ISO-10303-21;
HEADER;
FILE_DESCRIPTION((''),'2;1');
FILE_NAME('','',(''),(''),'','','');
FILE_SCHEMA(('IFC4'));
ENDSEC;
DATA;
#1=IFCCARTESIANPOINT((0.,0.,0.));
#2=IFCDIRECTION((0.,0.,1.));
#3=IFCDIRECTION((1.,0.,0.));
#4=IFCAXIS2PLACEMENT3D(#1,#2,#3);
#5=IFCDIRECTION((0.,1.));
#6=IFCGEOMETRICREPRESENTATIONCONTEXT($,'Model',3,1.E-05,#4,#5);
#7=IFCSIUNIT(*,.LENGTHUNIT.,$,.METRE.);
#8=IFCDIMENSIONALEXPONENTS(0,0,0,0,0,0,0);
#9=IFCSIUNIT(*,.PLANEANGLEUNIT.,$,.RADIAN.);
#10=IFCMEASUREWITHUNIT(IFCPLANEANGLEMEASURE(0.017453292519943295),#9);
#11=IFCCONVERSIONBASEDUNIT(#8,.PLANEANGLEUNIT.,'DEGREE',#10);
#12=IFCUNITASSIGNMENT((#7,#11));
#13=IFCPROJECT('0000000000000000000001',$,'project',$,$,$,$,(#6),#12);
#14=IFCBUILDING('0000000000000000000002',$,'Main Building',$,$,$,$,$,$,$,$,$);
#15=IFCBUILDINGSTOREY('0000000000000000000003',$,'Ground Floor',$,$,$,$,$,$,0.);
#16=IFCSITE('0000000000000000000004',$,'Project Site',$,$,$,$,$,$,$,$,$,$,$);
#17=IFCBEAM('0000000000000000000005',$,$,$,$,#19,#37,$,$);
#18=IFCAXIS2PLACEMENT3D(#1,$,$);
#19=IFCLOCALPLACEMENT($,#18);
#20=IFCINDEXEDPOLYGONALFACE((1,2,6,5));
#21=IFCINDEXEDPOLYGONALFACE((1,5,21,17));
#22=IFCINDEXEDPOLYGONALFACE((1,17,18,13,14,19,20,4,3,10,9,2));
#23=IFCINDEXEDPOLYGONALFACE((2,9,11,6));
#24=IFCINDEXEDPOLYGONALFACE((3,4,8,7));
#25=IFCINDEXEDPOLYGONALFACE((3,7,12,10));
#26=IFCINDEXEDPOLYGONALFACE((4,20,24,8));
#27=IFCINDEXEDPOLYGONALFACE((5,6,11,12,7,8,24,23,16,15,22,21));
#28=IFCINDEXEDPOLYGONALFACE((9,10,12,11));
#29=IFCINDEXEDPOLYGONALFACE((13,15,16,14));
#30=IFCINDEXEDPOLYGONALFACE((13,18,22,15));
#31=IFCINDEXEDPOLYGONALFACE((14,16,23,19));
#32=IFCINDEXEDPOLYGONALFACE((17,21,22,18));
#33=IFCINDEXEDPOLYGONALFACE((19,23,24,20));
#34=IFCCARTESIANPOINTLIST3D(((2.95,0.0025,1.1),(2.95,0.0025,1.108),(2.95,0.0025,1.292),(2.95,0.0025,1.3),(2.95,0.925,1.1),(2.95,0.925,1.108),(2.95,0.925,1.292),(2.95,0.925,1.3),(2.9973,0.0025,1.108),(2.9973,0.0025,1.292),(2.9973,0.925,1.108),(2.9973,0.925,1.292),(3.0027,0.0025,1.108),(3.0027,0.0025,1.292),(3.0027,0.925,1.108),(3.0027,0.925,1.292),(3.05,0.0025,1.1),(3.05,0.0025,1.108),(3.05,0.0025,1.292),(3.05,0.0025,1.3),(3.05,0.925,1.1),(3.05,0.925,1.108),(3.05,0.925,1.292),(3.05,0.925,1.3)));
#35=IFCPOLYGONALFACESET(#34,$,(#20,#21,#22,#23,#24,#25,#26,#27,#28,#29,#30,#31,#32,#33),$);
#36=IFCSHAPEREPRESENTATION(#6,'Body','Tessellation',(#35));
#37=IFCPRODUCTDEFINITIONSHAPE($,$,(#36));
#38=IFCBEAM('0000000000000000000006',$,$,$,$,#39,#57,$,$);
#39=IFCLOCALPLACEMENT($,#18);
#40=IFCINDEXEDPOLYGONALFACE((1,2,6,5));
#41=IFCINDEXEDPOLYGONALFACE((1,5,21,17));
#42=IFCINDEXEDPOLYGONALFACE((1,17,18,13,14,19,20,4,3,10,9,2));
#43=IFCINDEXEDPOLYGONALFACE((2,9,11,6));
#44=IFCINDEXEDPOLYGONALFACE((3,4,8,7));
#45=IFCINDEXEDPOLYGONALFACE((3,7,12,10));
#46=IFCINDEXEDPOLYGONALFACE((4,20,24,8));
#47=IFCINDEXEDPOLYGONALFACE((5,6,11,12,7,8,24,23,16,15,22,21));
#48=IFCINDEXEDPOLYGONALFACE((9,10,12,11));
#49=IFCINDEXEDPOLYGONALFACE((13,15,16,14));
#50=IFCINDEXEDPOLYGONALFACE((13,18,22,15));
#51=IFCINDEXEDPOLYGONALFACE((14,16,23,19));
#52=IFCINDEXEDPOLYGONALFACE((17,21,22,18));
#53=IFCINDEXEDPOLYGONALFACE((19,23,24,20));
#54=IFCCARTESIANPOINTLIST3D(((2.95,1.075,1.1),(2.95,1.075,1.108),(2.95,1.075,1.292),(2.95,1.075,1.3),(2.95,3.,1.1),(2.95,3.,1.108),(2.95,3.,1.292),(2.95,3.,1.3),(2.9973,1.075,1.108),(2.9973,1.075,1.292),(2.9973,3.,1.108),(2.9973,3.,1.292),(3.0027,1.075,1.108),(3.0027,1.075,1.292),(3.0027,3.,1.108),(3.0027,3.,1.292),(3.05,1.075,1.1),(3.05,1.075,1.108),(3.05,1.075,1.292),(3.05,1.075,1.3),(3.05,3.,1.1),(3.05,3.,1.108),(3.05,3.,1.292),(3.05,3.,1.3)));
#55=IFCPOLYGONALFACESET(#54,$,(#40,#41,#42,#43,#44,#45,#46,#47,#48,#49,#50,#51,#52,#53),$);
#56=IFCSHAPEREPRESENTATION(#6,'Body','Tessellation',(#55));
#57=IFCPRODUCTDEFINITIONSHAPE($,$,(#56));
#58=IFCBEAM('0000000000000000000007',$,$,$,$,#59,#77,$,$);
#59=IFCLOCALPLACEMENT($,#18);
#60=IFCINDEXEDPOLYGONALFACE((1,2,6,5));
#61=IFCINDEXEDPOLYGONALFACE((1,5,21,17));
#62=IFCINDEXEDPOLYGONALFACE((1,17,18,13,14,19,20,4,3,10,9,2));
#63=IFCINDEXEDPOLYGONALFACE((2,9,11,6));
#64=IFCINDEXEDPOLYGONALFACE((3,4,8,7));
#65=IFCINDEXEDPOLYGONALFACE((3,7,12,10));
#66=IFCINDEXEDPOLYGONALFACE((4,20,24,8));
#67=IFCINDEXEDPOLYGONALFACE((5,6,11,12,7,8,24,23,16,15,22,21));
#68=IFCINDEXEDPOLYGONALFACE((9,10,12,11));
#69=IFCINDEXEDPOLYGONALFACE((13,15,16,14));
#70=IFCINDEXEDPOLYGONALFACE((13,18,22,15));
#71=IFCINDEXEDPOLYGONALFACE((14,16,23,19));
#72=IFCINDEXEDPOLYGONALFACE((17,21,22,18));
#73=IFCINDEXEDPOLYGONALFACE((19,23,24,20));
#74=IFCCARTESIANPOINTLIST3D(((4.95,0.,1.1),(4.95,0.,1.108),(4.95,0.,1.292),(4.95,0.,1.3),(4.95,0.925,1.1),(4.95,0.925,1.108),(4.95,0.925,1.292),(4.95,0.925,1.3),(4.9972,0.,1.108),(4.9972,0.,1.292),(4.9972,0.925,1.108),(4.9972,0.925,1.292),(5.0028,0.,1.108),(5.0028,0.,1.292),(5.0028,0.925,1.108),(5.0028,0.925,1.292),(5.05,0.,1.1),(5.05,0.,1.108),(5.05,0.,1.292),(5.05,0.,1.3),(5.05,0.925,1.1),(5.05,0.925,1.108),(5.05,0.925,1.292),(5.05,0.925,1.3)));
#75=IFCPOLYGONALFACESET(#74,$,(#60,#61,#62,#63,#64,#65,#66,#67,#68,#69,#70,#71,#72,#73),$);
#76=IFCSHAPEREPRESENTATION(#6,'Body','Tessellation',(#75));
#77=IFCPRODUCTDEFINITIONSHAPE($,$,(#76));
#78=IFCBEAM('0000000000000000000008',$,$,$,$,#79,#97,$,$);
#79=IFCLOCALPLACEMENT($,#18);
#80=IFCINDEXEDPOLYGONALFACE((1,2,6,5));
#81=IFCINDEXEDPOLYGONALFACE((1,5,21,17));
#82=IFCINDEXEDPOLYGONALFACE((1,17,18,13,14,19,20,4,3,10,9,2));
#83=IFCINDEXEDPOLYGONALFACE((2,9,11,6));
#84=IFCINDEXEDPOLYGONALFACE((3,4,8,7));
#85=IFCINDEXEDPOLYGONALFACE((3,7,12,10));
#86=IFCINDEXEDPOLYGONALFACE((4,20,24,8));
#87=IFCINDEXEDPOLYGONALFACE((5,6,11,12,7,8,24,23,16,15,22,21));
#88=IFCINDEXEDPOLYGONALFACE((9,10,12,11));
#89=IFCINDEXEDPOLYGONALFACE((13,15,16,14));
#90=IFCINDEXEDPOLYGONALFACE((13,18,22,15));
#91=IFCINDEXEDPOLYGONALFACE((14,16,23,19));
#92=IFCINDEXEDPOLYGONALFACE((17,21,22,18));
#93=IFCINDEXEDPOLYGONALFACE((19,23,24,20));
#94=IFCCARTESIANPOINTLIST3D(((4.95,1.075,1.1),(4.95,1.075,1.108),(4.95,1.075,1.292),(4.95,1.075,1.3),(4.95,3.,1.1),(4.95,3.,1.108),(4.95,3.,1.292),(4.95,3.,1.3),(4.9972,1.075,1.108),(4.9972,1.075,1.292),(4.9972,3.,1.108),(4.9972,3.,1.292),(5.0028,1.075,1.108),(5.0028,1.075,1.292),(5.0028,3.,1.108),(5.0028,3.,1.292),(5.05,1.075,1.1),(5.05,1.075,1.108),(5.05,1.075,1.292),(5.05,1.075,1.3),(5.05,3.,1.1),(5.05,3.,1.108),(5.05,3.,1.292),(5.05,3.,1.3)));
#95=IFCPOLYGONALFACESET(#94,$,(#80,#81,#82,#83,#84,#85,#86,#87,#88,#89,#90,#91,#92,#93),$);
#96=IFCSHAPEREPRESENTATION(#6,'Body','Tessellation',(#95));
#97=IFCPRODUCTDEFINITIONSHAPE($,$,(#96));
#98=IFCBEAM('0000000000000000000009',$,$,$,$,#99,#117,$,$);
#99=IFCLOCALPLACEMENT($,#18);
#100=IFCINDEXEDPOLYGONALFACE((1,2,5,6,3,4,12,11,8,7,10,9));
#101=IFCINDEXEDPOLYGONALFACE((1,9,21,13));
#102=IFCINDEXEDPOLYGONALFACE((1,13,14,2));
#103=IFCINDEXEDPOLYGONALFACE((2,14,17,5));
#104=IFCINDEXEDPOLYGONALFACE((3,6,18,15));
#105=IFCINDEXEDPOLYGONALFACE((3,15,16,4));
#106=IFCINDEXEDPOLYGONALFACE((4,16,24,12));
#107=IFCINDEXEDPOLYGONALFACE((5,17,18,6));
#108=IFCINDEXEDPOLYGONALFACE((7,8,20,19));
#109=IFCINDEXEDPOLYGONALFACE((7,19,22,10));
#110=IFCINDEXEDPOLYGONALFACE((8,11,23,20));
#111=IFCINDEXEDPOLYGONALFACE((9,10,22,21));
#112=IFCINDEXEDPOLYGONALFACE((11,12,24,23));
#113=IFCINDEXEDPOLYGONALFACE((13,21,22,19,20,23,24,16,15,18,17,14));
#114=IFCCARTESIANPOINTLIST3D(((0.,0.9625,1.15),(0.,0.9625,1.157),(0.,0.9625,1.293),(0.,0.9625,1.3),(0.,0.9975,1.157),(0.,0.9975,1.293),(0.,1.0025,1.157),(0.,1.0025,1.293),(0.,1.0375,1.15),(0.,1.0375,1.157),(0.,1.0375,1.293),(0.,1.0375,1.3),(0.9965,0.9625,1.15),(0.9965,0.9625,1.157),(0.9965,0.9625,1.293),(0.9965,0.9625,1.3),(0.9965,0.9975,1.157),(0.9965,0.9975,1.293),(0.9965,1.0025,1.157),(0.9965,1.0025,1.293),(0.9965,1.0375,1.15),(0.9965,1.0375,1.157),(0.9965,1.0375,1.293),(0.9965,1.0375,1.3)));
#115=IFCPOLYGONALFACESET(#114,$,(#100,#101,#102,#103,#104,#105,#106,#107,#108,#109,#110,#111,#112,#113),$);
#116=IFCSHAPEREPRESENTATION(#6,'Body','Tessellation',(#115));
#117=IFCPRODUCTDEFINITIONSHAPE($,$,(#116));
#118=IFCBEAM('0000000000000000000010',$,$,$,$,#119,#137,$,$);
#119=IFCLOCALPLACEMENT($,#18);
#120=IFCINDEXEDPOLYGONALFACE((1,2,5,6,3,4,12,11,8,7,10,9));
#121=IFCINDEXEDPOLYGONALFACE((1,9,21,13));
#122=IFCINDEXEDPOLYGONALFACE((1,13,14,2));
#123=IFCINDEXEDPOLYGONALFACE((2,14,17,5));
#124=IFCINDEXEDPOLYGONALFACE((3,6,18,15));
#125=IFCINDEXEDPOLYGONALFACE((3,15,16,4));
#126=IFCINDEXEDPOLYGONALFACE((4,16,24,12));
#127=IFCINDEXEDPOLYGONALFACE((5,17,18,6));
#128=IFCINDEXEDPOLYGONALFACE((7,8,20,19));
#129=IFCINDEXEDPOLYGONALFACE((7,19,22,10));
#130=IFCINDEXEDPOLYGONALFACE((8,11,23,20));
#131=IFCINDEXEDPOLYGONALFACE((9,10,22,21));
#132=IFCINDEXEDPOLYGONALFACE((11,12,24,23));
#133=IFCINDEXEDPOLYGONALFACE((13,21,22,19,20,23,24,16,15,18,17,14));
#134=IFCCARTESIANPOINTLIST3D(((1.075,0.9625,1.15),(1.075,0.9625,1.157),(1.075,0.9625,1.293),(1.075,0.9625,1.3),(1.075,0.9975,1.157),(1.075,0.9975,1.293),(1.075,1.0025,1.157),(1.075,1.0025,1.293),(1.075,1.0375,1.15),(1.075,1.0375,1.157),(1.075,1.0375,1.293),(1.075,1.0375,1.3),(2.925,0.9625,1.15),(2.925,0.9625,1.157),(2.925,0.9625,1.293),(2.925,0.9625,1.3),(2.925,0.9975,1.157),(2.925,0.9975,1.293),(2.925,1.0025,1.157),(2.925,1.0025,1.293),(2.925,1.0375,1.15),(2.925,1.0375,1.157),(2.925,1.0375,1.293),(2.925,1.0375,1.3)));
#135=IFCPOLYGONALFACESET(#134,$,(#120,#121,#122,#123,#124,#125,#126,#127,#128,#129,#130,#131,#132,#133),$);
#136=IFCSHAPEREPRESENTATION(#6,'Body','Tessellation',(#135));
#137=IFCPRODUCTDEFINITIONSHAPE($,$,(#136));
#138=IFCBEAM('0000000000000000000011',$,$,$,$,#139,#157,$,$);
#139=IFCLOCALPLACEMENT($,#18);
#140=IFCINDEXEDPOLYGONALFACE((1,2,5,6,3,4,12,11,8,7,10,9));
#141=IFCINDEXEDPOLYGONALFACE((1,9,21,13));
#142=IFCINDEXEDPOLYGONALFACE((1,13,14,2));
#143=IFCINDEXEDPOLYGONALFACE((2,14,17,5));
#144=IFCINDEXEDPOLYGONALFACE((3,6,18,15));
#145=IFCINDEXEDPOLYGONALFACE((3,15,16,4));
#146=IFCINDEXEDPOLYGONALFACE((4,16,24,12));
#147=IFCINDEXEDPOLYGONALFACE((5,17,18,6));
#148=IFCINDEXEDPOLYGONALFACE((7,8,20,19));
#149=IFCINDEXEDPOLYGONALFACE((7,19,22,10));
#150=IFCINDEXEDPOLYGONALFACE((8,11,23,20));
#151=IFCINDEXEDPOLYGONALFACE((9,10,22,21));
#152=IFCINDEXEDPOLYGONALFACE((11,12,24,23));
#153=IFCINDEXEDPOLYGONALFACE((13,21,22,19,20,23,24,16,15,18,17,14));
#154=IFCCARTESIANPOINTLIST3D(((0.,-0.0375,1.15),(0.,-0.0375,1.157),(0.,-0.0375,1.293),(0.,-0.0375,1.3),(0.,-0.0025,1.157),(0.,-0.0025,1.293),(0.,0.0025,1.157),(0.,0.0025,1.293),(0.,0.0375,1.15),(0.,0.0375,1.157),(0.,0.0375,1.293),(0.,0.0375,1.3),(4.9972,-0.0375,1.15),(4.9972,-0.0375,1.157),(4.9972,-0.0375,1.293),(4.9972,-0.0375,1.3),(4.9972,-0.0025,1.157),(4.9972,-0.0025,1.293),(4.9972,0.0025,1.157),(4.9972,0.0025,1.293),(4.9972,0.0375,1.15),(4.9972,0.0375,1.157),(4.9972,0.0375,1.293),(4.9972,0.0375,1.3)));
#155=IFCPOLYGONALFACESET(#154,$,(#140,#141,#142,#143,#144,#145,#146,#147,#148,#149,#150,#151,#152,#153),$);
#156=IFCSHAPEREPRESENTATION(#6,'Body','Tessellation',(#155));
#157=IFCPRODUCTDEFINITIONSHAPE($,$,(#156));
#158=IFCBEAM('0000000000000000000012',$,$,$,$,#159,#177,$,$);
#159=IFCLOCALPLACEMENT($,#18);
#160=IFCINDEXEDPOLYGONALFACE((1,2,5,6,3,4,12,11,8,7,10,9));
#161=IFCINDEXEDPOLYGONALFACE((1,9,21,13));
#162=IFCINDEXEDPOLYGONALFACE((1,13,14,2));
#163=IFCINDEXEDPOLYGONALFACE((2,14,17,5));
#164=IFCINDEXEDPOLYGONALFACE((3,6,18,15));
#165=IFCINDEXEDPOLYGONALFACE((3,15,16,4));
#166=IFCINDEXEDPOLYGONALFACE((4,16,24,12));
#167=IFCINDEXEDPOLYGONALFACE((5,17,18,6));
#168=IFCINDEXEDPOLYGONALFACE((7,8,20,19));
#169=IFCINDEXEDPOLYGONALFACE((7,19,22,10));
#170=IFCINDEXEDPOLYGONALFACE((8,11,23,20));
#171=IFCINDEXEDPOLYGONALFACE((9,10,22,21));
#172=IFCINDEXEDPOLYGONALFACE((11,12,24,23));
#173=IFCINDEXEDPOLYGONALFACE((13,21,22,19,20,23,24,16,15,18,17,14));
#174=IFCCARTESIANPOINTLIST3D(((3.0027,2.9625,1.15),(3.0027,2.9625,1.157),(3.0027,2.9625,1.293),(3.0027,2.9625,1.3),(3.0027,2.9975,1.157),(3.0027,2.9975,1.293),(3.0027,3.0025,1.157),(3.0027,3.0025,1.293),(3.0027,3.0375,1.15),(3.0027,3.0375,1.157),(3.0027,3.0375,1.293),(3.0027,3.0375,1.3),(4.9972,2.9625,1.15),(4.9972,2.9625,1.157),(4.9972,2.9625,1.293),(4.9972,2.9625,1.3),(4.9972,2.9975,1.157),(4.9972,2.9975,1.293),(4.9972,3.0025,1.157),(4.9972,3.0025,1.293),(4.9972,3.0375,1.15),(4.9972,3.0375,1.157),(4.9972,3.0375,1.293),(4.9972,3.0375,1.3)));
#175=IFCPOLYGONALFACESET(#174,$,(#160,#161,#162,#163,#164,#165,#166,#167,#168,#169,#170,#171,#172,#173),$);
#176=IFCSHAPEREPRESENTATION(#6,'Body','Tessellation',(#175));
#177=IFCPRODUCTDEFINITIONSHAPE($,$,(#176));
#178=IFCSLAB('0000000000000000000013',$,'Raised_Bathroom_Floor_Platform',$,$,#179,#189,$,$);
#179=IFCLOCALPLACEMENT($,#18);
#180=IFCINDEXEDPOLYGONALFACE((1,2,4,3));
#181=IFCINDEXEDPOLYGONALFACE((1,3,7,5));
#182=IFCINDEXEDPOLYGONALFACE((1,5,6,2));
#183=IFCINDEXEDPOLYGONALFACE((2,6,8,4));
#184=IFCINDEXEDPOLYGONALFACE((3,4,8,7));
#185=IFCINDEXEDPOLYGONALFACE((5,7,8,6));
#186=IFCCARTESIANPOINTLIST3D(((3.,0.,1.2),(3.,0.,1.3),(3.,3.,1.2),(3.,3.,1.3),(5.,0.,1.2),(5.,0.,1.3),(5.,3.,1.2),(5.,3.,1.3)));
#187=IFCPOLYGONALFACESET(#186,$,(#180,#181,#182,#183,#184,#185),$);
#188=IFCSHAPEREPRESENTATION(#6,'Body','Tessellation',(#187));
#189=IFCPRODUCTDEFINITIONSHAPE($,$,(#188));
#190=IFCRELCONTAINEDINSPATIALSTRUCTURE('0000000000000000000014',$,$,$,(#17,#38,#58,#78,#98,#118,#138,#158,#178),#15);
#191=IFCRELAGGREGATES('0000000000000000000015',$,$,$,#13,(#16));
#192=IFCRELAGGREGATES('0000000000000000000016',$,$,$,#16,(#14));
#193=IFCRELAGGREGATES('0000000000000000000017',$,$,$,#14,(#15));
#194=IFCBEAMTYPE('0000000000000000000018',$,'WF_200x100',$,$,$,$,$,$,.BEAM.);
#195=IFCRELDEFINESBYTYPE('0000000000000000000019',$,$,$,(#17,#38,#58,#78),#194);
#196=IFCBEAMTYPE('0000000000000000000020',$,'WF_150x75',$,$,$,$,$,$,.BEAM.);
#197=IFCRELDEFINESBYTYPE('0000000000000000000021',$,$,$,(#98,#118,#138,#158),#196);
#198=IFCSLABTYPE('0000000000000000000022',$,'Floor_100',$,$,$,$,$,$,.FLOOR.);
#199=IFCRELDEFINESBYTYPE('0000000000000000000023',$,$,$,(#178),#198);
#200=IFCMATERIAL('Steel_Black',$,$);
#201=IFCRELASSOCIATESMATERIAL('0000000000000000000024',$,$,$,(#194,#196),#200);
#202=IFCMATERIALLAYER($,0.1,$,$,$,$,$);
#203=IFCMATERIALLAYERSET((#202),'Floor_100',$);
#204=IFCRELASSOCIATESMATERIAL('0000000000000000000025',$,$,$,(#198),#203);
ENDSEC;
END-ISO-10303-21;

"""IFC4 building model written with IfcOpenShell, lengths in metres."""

from ifc_helpers import new_model, entity, si_unit, converted_unit, direction, frame, frame_2d, origin, origin_with_axes, origin_2d, place, context, project, spatial, polyline, i_section, outline, extrude, material, layer, layer_set, material_profile, profile_set, type_object, element, save


model = new_model("IFC4")

# Units and contexts
model_context = context("Model", 3, precision=1e-05, world=origin_with_axes(), true_north=direction((0.0, 1.0)))
ifc_project = project(units=[si_unit("LENGTHUNIT", "METRE"), converted_unit("PLANEANGLEUNIT", "DEGREE", entity("IfcPlaneAngleMeasure", 0.017453292519943295), si_unit("PLANEANGLEUNIT", "RADIAN"), dimensions=[0, 0, 0, 0, 0, 0, 0])], contexts=[model_context])

# Site, building, storey
site = spatial("IfcSite", under=ifc_project, Name="Project Site")
building = spatial("IfcBuilding", under=site, Name="Main Building")
storey = spatial("IfcBuildingStorey", under=building, Name="Ground Floor", Elevation=0.0)

# Shared definitions
ifc_material_1 = material(Name="Steel_Black")

# Beams
ifc_material_profile_1 = material_profile(ifc_material_1, i_section(OverallWidth=0.1, OverallDepth=0.2, WebThickness=0.0055, FlangeThickness=0.008, at=origin_2d()), Name="WF_200x100")
ifc_profile_set_1 = profile_set([ifc_material_profile_1], Name="WF_200x100")
beam_type_1 = type_object("IfcBeamType", Name="WF_200x100", PredefinedType="BEAM", material=ifc_profile_set_1)
for number, where, z_axis, x_axis in (
    (1, (3.0, 0.0025, 1.1), (0.0, 0.0, 1.0), (0.0, 1.0, 0.0)),
):
    element("IfcBeam", number, at=place(None, frame(where, z_axis=z_axis, x_axis=x_axis)), inside=storey, type_object=beam_type_1, context=model_context, shape_type="SweptSolid", body=[
        extrude(i_section(OverallWidth=0.1, OverallDepth=0.2, WebThickness=0.0055, FlangeThickness=0.008, at=frame_2d((0.0, 0.1))), frame((0.0, 0.0, 0.0), z_axis=(1.0, 0.0, 0.0), x_axis=(0.0, 1.0, 0.0)), (0.0, 0.0, 1.0), 0.9225),
    ])
beam_1_placement = place(None, frame((3.0, 1.075, 1.1), z_axis=(0.0, 0.0, 1.0), x_axis=(0.0, 1.0, 0.0)))
element("IfcBeam", 2, at=beam_1_placement, inside=storey, type_object=beam_type_1, context=model_context, shape_type="SweptSolid", body=[
    extrude(i_section(OverallWidth=0.1, OverallDepth=0.2, WebThickness=0.0055, FlangeThickness=0.008, at=frame_2d((0.0, 0.1))), frame((0.0, 0.0, 0.0), z_axis=(1.0, 0.0, 0.0), x_axis=(0.0, 1.0, 0.0)), (0.0, 0.0, 1.0), 1.925),
])
beam_2_placement = place(None, frame((5.0, 0.0, 1.1), z_axis=(0.0, 0.0, 1.0), x_axis=(0.0, 1.0, 0.0)))
element("IfcBeam", 3, at=beam_2_placement, inside=storey, type_object=beam_type_1, context=model_context, shape_type="SweptSolid", body=[
    extrude(i_section(OverallWidth=0.1, OverallDepth=0.2, WebThickness=0.0055, FlangeThickness=0.008, at=frame_2d((0.0, 0.1))), frame((0.0, 0.0, 0.0), z_axis=(1.0, 0.0, 0.0), x_axis=(0.0, 1.0, 0.0)), (0.0, 0.0, 1.0), 0.925),
])
beam_3_placement = place(None, frame((5.0, 1.075, 1.1), z_axis=(0.0, 0.0, 1.0), x_axis=(0.0, 1.0, 0.0)))
element("IfcBeam", 4, at=beam_3_placement, inside=storey, type_object=beam_type_1, context=model_context, shape_type="SweptSolid", body=[
    extrude(i_section(OverallWidth=0.1, OverallDepth=0.2, WebThickness=0.0055, FlangeThickness=0.008, at=frame_2d((0.0, 0.1))), frame((0.0, 0.0, 0.0), z_axis=(1.0, 0.0, 0.0), x_axis=(0.0, 1.0, 0.0)), (0.0, 0.0, 1.0), 1.925),
])
ifc_material_profile_2 = material_profile(ifc_material_1, i_section(OverallWidth=0.075, OverallDepth=0.15, WebThickness=0.005, FlangeThickness=0.007, at=origin_2d()), Name="WF_150x75")
ifc_profile_set_2 = profile_set([ifc_material_profile_2], Name="WF_150x75")
beam_type_2 = type_object("IfcBeamType", Name="WF_150x75", PredefinedType="BEAM", material=ifc_profile_set_2)
beam_4_placement = place(None, frame((0.0, 1.0, 1.15), z_axis=(0.0, 0.0, 1.0), x_axis=(1.0, 0.0, 0.0)))
element("IfcBeam", 5, at=beam_4_placement, inside=storey, type_object=beam_type_2, context=model_context, shape_type="SweptSolid", body=[
    extrude(i_section(OverallWidth=0.075, OverallDepth=0.15, WebThickness=0.005, FlangeThickness=0.007, at=frame_2d((0.0, 0.075))), frame((0.0, 0.0, 0.0), z_axis=(1.0, 0.0, 0.0), x_axis=(0.0, 1.0, 0.0)), (0.0, 0.0, 1.0), 0.9965),
])
beam_5_placement = place(None, frame((1.075, 1.0, 1.15), z_axis=(0.0, 0.0, 1.0), x_axis=(1.0, 0.0, 0.0)))
element("IfcBeam", 6, at=beam_5_placement, inside=storey, type_object=beam_type_2, context=model_context, shape_type="SweptSolid", body=[
    extrude(i_section(OverallWidth=0.075, OverallDepth=0.15, WebThickness=0.005, FlangeThickness=0.007, at=frame_2d((0.0, 0.075))), frame((0.0, 0.0, 0.0), z_axis=(1.0, 0.0, 0.0), x_axis=(0.0, 1.0, 0.0)), (0.0, 0.0, 1.0), 1.85),
])
beam_6_placement = place(None, frame((0.0, 0.0, 1.15), z_axis=(0.0, 0.0, 1.0), x_axis=(1.0, 0.0, 0.0)))
element("IfcBeam", 7, at=beam_6_placement, inside=storey, type_object=beam_type_2, context=model_context, shape_type="SweptSolid", body=[
    extrude(i_section(OverallWidth=0.075, OverallDepth=0.15, WebThickness=0.005, FlangeThickness=0.007, at=frame_2d((0.0, 0.075))), frame((0.0, 0.0, 0.0), z_axis=(1.0, 0.0, 0.0), x_axis=(0.0, 1.0, 0.0)), (0.0, 0.0, 1.0), 4.9973),
])
beam_7_placement = place(None, frame((3.0027, 3.0, 1.15), z_axis=(0.0, 0.0, 1.0), x_axis=(1.0, 0.0, 0.0)))
element("IfcBeam", 8, at=beam_7_placement, inside=storey, type_object=beam_type_2, context=model_context, shape_type="SweptSolid", body=[
    extrude(i_section(OverallWidth=0.075, OverallDepth=0.15, WebThickness=0.005, FlangeThickness=0.007, at=frame_2d((0.0, 0.075))), frame((0.0, 0.0, 0.0), z_axis=(1.0, 0.0, 0.0), x_axis=(0.0, 1.0, 0.0)), (0.0, 0.0, 1.0), 1.9945),
])

# Slab
ifc_layer_1 = layer(None, 0.1)
ifc_layer_set_1 = layer_set([ifc_layer_1], Name="Floor_100")
slab_type_1 = type_object("IfcSlabType", Name="Floor_100", PredefinedType="FLOOR", material=ifc_layer_set_1)
slab_1_placement = place(None, frame((0.0, 0.0, 1.2), z_axis=(0.0, 0.0, 1.0), x_axis=(1.0, 0.0, 0.0)))
element("IfcSlab", 9, at=slab_1_placement, inside=storey, type_object=slab_type_1, Name="Raised_Bathroom_Floor_Platform", context=model_context, shape_type="SweptSolid", body=[
    extrude(outline(polyline([(3.0, 0.0), (5.0, 0.0), (5.0, 3.0), (3.0, 3.0), (3.0, 0.0)])), origin(), (0.0, 0.0, 1.0), 0.1),
])

save(model, "model.ifc")
